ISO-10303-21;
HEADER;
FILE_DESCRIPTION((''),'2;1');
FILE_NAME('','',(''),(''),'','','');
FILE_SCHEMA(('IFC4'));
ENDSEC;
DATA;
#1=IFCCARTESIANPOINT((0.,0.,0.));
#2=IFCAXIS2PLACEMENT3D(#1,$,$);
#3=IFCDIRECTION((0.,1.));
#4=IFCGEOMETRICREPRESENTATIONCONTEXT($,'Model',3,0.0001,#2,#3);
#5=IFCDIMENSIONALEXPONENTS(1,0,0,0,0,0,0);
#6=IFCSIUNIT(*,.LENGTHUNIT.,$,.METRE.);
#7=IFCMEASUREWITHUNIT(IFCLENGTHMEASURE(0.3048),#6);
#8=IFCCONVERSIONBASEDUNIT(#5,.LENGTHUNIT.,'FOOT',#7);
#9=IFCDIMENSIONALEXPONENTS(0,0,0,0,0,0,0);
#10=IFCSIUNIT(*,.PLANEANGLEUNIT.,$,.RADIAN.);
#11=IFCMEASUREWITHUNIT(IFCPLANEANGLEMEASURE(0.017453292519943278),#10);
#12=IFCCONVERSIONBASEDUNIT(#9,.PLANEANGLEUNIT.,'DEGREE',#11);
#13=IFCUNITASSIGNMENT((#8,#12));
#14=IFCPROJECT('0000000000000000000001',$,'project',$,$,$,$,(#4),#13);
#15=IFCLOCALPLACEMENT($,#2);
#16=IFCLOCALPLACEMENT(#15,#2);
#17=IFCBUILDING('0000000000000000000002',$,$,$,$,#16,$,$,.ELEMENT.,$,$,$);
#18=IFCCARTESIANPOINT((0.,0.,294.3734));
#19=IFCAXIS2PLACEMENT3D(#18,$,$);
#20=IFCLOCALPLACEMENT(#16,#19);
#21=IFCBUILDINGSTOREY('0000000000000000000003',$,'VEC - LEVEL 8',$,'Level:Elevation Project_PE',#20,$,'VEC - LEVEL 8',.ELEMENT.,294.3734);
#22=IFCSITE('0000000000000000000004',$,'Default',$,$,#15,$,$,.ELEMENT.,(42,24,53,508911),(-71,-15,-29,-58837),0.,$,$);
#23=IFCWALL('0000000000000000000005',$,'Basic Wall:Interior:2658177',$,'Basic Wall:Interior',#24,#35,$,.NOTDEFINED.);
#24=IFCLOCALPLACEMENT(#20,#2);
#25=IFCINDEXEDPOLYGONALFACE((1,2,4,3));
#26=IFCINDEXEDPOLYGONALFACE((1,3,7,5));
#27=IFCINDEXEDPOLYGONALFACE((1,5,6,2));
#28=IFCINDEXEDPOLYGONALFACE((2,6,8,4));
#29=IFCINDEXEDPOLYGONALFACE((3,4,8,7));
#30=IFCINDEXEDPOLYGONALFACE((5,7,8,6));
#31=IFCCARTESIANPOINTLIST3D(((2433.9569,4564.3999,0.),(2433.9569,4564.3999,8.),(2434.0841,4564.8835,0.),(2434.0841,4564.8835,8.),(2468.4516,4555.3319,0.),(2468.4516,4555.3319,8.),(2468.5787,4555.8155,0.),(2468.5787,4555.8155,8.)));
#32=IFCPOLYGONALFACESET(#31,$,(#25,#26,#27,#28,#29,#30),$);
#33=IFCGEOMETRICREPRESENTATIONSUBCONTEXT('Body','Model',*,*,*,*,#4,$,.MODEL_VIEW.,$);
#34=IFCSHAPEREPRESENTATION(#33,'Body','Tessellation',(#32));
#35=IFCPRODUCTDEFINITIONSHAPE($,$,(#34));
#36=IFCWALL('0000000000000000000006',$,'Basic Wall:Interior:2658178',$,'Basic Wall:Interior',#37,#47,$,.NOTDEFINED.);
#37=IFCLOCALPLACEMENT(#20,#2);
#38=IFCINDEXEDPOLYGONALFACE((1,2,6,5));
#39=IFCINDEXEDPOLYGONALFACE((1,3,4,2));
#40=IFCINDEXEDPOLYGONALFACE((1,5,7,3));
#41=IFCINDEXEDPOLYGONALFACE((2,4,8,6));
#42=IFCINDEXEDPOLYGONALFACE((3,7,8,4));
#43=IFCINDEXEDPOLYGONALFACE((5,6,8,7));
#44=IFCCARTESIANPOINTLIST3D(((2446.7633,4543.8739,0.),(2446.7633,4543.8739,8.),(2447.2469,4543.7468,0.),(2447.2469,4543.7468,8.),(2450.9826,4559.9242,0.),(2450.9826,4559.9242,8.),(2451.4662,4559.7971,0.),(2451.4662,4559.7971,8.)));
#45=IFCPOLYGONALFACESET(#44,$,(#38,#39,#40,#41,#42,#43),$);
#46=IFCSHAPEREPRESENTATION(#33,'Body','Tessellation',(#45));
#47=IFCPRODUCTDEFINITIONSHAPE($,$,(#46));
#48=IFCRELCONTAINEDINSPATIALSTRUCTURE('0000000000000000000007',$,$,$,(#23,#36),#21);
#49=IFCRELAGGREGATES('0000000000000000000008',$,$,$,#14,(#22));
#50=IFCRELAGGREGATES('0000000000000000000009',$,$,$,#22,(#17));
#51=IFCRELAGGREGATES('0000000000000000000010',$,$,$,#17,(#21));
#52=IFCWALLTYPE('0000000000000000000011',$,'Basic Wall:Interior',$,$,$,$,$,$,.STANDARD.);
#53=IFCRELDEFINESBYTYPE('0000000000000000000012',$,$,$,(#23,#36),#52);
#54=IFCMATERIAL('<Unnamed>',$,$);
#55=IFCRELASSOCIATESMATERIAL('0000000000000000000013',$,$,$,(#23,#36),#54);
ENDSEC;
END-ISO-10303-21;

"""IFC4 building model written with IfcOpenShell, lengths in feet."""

from ifc_helpers import new_model, entity, si_unit, converted_unit, direction, frame, origin, place, context, subcontext, project, spatial, indexed_curve, outline, extrude, material, type_object, element, save


model = new_model("IFC4")

# Units and contexts
model_context = context("Model", 3, precision=0.0001, world=origin(), true_north=direction((0.0, 1.0)))
body_context = subcontext(model_context, "Body", "Model", "MODEL_VIEW")
ifc_project = project(units=[converted_unit("LENGTHUNIT", "FOOT", entity("IfcLengthMeasure", 0.3048), si_unit("LENGTHUNIT", "METRE"), dimensions=[1, 0, 0, 0, 0, 0, 0]), converted_unit("PLANEANGLEUNIT", "DEGREE", entity("IfcPlaneAngleMeasure", 0.017453292519943278), si_unit("PLANEANGLEUNIT", "RADIAN"), dimensions=[0, 0, 0, 0, 0, 0, 0])], contexts=[model_context])

# Site, building, storey
site_placement = place(None, origin())
site = spatial("IfcSite", under=ifc_project, at=site_placement, Name="Default", CompositionType="ELEMENT", RefLatitude=(42, 24, 53, 508911), RefLongitude=(-71, -15, -29, -58837), RefElevation=0.0)
building_placement = place(site_placement, origin())
building = spatial("IfcBuilding", under=site, at=building_placement, CompositionType="ELEMENT")
storey_placement = place(building_placement, frame((0.0, 0.0, 294.3734)))
storey = spatial("IfcBuildingStorey", under=building, at=storey_placement, Name="VEC - LEVEL 8", ObjectType="Level:Elevation Project_PE", LongName="VEC - LEVEL 8", CompositionType="ELEMENT", Elevation=294.3734)

# Walls
ifc_material = material(Name="<Unnamed>")
wall_type = type_object("IfcWallType", Name="Basic Wall:Interior", PredefinedType="STANDARD")
wall_1_placement = place(storey_placement, frame((2434.0205, 4564.6417, 0.0), z_axis=(0.0, 0.0, 1.0), x_axis=(0.96714, -0.254244, 0.0)))
element("IfcWall", 1, at=wall_1_placement, inside=storey, type_object=wall_type, material=ifc_material, Name="Basic Wall:Interior:2658177", ObjectType="Basic Wall:Interior", PredefinedType="NOTDEFINED", context=body_context, shape_type="SweptSolid", body=[
    extrude(outline(indexed_curve([(35.6667, 0.25), (0.0, 0.25), (0.0, -0.25), (35.6667, -0.25), (35.6667, 0.25)], self_intersect=False)), origin(), (0.0, 0.0, 1.0), 8.0),
])
wall_2_placement = place(storey_placement, frame((2451.2244, 4559.8606, 0.0), z_axis=(0.0, 0.0, 1.0), x_axis=(-0.254244, -0.96714, 0.0)))
element("IfcWall", 2, at=wall_2_placement, inside=storey, type_object=wall_type, material=ifc_material, Name="Basic Wall:Interior:2658178", ObjectType="Basic Wall:Interior", PredefinedType="NOTDEFINED", context=body_context, shape_type="SweptSolid", body=[
    extrude(outline(indexed_curve([(16.5956, 0.25), (0.0, 0.25), (0.0, -0.25), (16.5956, -0.25), (16.5956, 0.25)], self_intersect=False)), origin(), (0.0, 0.0, 1.0), 8.0),
])

save(model, "model.ifc")
